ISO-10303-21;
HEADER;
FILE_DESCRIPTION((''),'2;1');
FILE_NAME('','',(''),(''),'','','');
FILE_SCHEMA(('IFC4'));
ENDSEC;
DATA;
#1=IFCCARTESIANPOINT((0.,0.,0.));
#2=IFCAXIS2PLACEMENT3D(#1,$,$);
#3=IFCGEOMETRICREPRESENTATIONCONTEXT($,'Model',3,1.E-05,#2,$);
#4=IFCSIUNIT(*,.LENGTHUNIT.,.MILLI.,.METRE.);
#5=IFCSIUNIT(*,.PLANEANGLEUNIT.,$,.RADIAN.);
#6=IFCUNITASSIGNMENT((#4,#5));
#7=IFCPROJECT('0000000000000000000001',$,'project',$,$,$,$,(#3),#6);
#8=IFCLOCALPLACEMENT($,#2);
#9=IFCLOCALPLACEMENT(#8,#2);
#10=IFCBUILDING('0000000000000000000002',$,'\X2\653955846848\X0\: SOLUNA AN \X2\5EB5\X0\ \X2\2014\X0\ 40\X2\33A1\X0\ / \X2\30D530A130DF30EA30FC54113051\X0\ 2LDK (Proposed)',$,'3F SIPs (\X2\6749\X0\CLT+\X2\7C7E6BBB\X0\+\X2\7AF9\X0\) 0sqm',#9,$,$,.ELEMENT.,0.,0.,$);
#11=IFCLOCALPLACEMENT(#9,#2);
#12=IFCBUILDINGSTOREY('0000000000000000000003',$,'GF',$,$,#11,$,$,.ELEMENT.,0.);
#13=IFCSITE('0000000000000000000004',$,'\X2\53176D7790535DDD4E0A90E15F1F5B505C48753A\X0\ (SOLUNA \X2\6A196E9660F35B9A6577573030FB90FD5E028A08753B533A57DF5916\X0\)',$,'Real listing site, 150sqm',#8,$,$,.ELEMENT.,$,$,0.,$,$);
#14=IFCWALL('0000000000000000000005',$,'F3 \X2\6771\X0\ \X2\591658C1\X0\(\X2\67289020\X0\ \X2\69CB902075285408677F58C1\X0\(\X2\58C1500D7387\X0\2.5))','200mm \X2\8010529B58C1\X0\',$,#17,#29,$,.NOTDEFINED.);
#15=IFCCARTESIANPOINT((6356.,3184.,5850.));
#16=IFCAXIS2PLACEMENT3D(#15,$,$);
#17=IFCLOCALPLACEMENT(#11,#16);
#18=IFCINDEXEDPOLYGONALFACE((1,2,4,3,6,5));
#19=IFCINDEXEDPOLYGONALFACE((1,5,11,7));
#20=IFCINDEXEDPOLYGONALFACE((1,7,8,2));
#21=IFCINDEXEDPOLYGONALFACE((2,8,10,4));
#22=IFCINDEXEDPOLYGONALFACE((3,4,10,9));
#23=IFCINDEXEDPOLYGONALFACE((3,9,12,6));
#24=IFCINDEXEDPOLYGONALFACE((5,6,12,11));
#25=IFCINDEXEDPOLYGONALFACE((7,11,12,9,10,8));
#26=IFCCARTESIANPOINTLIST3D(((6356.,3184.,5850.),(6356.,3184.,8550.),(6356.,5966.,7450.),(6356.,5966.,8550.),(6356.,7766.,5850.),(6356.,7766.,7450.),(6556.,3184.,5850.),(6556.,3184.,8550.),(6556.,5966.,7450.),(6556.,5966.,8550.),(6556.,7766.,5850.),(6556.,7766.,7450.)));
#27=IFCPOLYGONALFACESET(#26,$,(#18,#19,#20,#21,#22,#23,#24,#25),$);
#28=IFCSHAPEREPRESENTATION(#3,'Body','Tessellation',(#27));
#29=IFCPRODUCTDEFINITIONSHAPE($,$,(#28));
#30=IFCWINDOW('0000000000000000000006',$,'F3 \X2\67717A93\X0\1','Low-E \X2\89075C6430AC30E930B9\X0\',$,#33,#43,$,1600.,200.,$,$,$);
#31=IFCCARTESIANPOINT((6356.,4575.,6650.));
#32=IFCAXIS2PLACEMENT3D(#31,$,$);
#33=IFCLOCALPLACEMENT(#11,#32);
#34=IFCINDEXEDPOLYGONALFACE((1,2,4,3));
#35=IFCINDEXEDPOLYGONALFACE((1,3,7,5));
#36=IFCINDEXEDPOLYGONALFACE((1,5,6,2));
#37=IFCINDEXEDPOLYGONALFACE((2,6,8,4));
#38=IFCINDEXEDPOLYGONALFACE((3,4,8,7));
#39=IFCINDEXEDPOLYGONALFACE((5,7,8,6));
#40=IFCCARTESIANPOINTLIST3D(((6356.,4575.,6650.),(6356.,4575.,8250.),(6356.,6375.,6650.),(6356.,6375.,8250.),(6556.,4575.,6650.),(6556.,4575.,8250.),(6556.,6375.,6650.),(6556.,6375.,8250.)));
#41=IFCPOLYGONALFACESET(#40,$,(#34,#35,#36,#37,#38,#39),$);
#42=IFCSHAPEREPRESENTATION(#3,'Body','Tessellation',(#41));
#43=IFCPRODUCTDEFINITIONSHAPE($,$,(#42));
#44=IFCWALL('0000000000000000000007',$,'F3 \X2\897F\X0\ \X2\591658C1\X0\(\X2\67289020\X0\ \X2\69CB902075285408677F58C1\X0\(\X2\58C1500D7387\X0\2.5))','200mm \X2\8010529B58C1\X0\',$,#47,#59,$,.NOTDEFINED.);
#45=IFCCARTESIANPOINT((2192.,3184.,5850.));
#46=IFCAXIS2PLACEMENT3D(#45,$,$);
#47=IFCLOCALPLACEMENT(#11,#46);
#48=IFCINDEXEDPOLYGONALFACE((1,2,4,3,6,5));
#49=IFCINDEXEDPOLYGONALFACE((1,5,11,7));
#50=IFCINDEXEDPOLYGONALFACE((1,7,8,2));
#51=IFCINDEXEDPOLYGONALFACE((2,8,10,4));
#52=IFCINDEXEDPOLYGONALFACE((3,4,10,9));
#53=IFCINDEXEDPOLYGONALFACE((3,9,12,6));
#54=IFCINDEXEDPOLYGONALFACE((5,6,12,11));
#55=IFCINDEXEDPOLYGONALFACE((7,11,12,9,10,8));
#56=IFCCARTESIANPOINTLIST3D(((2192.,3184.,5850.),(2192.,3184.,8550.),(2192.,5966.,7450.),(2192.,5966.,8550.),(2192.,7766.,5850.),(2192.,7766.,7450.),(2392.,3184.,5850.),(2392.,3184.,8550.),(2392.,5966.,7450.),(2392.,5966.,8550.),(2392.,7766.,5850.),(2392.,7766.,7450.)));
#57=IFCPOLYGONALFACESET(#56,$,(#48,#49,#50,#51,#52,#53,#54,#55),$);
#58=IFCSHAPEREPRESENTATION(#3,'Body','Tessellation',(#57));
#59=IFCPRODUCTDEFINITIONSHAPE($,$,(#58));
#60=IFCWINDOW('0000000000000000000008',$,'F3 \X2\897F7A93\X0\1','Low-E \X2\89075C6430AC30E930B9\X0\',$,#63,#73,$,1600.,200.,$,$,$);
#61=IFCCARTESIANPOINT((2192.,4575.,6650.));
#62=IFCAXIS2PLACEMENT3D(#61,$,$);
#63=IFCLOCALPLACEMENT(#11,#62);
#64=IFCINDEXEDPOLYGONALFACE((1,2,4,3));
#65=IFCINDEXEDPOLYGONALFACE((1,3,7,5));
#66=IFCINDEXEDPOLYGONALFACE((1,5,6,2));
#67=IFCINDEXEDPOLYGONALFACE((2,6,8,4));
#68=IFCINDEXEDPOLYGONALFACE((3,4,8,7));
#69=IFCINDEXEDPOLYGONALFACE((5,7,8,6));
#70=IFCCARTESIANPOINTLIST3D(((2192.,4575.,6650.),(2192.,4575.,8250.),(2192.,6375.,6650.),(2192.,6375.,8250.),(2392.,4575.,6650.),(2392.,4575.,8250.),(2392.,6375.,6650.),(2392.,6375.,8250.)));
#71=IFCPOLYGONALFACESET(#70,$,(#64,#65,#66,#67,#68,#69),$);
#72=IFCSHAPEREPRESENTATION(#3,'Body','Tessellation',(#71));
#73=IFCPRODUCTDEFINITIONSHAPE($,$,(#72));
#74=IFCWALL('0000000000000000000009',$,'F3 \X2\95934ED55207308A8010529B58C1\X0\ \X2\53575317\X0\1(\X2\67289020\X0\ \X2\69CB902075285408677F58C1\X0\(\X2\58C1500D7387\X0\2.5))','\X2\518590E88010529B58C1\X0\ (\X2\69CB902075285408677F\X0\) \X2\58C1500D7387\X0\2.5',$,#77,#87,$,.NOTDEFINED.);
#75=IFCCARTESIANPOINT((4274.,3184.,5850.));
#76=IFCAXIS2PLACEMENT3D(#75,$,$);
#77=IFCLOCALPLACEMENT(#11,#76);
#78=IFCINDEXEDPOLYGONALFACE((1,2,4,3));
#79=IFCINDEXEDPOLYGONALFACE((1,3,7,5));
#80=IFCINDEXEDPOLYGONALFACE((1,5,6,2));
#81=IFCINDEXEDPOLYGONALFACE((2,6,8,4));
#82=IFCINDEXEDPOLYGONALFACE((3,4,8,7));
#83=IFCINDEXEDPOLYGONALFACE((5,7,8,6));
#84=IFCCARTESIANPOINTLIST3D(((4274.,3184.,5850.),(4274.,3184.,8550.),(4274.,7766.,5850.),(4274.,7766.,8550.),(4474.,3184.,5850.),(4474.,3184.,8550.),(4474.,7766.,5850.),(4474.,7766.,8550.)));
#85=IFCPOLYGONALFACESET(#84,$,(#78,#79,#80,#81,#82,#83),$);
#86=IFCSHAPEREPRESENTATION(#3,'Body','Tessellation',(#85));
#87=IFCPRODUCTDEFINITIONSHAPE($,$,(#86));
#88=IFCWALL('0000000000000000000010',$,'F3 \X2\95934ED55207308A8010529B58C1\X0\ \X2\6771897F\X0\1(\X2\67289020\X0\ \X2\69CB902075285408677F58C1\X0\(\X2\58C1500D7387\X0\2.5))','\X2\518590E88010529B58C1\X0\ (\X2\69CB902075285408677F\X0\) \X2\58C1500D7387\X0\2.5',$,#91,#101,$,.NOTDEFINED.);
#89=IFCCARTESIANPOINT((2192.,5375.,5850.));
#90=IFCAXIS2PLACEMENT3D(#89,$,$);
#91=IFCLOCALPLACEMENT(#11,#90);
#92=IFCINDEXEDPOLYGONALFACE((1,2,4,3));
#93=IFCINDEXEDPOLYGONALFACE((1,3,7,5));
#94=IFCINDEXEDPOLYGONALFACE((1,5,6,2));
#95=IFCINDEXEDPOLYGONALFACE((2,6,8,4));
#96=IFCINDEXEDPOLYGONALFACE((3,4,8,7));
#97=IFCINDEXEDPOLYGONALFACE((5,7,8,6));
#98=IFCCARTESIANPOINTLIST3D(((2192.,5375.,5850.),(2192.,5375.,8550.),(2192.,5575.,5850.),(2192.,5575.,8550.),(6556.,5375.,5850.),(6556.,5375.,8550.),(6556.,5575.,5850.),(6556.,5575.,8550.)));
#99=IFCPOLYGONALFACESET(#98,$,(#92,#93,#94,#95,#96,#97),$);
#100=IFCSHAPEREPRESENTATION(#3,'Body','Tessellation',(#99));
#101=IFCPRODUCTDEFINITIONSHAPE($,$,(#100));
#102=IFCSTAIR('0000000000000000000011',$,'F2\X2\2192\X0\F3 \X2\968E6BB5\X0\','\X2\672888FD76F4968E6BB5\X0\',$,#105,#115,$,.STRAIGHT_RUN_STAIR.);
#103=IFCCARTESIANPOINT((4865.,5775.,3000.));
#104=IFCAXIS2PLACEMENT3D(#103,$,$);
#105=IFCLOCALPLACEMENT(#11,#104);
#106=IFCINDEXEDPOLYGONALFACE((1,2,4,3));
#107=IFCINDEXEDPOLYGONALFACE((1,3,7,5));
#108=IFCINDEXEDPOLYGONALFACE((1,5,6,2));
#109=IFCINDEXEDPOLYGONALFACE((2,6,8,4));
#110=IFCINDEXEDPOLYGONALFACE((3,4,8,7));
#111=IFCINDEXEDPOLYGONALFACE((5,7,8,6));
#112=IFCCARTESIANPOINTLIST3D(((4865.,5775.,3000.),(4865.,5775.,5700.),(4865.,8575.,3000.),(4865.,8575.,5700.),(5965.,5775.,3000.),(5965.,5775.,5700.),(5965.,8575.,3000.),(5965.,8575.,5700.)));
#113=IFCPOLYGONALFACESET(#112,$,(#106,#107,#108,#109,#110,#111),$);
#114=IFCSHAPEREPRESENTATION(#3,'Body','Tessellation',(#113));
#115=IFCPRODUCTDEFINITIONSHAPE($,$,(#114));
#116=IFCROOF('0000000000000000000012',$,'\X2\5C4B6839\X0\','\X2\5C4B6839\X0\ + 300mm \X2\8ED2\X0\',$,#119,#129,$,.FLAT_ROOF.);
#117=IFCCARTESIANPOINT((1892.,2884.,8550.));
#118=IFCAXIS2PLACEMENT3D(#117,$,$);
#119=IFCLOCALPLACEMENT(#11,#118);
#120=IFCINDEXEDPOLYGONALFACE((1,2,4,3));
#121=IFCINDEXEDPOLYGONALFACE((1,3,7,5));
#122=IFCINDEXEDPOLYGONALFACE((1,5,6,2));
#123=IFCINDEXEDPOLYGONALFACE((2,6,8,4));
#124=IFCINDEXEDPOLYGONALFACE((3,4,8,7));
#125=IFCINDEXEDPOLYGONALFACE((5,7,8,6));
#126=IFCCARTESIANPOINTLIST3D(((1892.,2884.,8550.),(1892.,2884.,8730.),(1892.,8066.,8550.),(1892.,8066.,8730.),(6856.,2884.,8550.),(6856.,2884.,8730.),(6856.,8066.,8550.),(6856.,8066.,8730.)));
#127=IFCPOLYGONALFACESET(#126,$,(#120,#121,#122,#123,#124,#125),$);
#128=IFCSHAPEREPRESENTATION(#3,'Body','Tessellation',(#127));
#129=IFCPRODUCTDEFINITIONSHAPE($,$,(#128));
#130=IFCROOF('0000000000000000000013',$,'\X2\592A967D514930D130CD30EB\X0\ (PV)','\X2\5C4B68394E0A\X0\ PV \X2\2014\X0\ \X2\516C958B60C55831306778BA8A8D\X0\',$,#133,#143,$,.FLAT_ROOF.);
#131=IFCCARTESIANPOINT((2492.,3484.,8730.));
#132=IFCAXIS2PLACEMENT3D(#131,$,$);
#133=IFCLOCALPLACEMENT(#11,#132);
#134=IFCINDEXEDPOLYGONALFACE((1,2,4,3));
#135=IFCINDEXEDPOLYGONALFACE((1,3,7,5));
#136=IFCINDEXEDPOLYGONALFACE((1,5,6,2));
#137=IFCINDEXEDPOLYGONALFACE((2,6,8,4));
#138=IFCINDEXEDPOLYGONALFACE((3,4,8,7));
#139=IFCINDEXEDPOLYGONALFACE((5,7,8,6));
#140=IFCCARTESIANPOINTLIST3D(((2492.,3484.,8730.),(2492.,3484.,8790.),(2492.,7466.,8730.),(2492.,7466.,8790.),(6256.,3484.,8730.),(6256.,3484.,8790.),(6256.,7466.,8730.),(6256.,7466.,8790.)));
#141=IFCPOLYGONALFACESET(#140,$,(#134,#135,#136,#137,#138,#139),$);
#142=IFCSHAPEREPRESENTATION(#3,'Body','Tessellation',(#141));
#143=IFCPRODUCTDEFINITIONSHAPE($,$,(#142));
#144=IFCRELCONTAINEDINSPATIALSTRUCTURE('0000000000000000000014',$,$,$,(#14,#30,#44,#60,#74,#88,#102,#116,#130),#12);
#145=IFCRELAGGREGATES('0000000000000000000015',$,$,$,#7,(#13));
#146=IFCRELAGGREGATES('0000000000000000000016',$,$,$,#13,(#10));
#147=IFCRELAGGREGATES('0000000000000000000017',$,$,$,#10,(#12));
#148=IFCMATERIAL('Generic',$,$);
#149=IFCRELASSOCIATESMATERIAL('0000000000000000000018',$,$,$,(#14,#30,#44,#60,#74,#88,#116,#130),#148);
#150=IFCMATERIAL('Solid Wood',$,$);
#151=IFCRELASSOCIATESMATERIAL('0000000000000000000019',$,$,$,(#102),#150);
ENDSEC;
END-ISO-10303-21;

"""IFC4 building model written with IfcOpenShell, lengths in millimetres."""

from ifc_helpers import new_model, si_unit, frame, frame_2d, origin, place, context, project, spatial, rectangle, extrude, material, element, fill, save


model = new_model("IFC4")

# Units and contexts
model_context = context("Model", 3, precision=1e-05, world=origin())
ifc_project = project(units=[si_unit("LENGTHUNIT", "METRE", prefix="MILLI"), si_unit("PLANEANGLEUNIT", "RADIAN")], contexts=[model_context])

# Site, building, storey
site_placement = place(None, origin())
site = spatial("IfcSite", under=ifc_project, at=site_placement, Name="北海道川上郡弟子屈町 (SOLUNA 標準想定敷地・都市計画区域外)", ObjectType="Real listing site, 150sqm", CompositionType="ELEMENT", RefElevation=0.0)
building_placement = place(site_placement, origin())
building = spatial("IfcBuilding", under=site, at=building_placement, Name="改善案: SOLUNA AN 庵 — 40㎡ / ファミリー向け 2LDK (Proposed)", ObjectType="3F SIPs (杉CLT+籾殻+竹) 0sqm", CompositionType="ELEMENT", ElevationOfRefHeight=0.0, ElevationOfTerrain=0.0)
storey_placement = place(building_placement, origin())
storey = spatial("IfcBuildingStorey", under=building, at=storey_placement, Name="GF", CompositionType="ELEMENT", Elevation=0.0)

# Shared definitions
ifc_material_1 = material(Name="Generic")

# Walls, openings, windows
wall_1_placement = place(storey_placement, frame((6356.0, 3184.0, 5850.0)))
wall_1 = element("IfcWall", 1, at=wall_1_placement, inside=storey, material=ifc_material_1, Name="F3 東 外壁(木造 構造用合板壁(壁倍率2.5))", Description="200mm 耐力壁", PredefinedType="NOTDEFINED", context=model_context, shape_type="SweptSolid", body=[
    extrude(rectangle(XDim=200.0, YDim=4582.0, at=frame_2d((100.0, 2291.0))), frame((6356.0, 3184.0, 5850.0)), (0.0, 0.0, 1.0), 2700.0),
])
opening_1_placement = place(storey_placement, frame((6356.0, 4575.0, 6650.0)))
opening_1 = element("IfcOpeningElement", 2, at=opening_1_placement, cuts=wall_1, PredefinedType="NOTDEFINED", context=model_context, shape_type="SweptSolid", body=[
    extrude(rectangle(XDim=200.0, YDim=1800.0, at=frame_2d((100.0, 900.0))), frame((6356.0, 4575.0, 6650.0)), (0.0, 0.0, 1.0), 1600.0),
])
window_1_placement = place(storey_placement, frame((6356.0, 4575.0, 6650.0)))
window_1 = element("IfcWindow", 3, at=window_1_placement, inside=storey, material=ifc_material_1, Name="F3 東窓1", Description="Low-E 複層ガラス", OverallHeight=1600.0, OverallWidth=200.0, context=model_context, shape_type="SweptSolid", body=[
    extrude(rectangle(XDim=200.0, YDim=1800.0, at=frame_2d((100.0, 900.0))), frame((6356.0, 4575.0, 6650.0)), (0.0, 0.0, 1.0), 1600.0),
])
fill(opening_1, window_1)
wall_2_placement = place(storey_placement, frame((2192.0, 3184.0, 5850.0)))
wall_2 = element("IfcWall", 4, at=wall_2_placement, inside=storey, material=ifc_material_1, Name="F3 西 外壁(木造 構造用合板壁(壁倍率2.5))", Description="200mm 耐力壁", PredefinedType="NOTDEFINED", context=model_context, shape_type="SweptSolid", body=[
    extrude(rectangle(XDim=200.0, YDim=4582.0, at=frame_2d((100.0, 2291.0))), frame((2192.0, 3184.0, 5850.0)), (0.0, 0.0, 1.0), 2700.0),
])
opening_2_placement = place(storey_placement, frame((2192.0, 4575.0, 6650.0)))
opening_2 = element("IfcOpeningElement", 5, at=opening_2_placement, cuts=wall_2, PredefinedType="NOTDEFINED", context=model_context, shape_type="SweptSolid", body=[
    extrude(rectangle(XDim=200.0, YDim=1800.0, at=frame_2d((100.0, 900.0))), frame((2192.0, 4575.0, 6650.0)), (0.0, 0.0, 1.0), 1600.0),
])
window_2_placement = place(storey_placement, frame((2192.0, 4575.0, 6650.0)))
window_2 = element("IfcWindow", 6, at=window_2_placement, inside=storey, material=ifc_material_1, Name="F3 西窓1", Description="Low-E 複層ガラス", OverallHeight=1600.0, OverallWidth=200.0, context=model_context, shape_type="SweptSolid", body=[
    extrude(rectangle(XDim=200.0, YDim=1800.0, at=frame_2d((100.0, 900.0))), frame((2192.0, 4575.0, 6650.0)), (0.0, 0.0, 1.0), 1600.0),
])
fill(opening_2, window_2)

# Walls
wall_3_placement = place(storey_placement, frame((4274.0, 3184.0, 5850.0)))
element("IfcWall", 7, at=wall_3_placement, inside=storey, material=ifc_material_1, Name="F3 間仕切り耐力壁 南北1(木造 構造用合板壁(壁倍率2.5))", Description="内部耐力壁 (構造用合板) 壁倍率2.5", PredefinedType="NOTDEFINED", context=model_context, shape_type="SweptSolid", body=[
    extrude(rectangle(XDim=200.0, YDim=4582.0, at=frame_2d((100.0, 2291.0))), frame((4274.0, 3184.0, 5850.0)), (0.0, 0.0, 1.0), 2700.0),
])
wall_4_placement = place(storey_placement, frame((2192.0, 5375.0, 5850.0)))
element("IfcWall", 8, at=wall_4_placement, inside=storey, material=ifc_material_1, Name="F3 間仕切り耐力壁 東西1(木造 構造用合板壁(壁倍率2.5))", Description="内部耐力壁 (構造用合板) 壁倍率2.5", PredefinedType="NOTDEFINED", context=model_context, shape_type="SweptSolid", body=[
    extrude(rectangle(XDim=4364.0, YDim=200.0, at=frame_2d((2182.0, 100.0))), frame((2192.0, 5375.0, 5850.0)), (0.0, 0.0, 1.0), 2700.0),
])

# Stair
ifc_material_2 = material(Name="Solid Wood")
stair_placement = place(storey_placement, frame((4865.0, 5775.0, 3000.0)))
element("IfcStair", 9, at=stair_placement, inside=storey, material=ifc_material_2, Name="F2→F3 階段", Description="木製直階段", PredefinedType="STRAIGHT_RUN_STAIR", context=model_context, shape_type="SweptSolid", body=[
    extrude(rectangle(XDim=1100.0, YDim=2800.0, at=frame_2d((550.0, 1400.0))), frame((4865.0, 5775.0, 3000.0)), (0.0, 0.0, 1.0), 2700.0),
])

# Roofs
roof_1_placement = place(storey_placement, frame((1892.0, 2884.0, 8550.0)))
element("IfcRoof", 10, at=roof_1_placement, inside=storey, material=ifc_material_1, Name="屋根", Description="屋根 + 300mm 軒", PredefinedType="FLAT_ROOF", context=model_context, shape_type="SweptSolid", body=[
    extrude(rectangle(XDim=4964.0, YDim=5182.0, at=frame_2d((2482.0, 2591.0))), frame((1892.0, 2884.0, 8550.0)), (0.0, 0.0, 1.0), 180.0),
])
roof_2_placement = place(storey_placement, frame((2492.0, 3484.0, 8730.0)))
element("IfcRoof", 11, at=roof_2_placement, inside=storey, material=ifc_material_1, Name="太陽光パネル (PV)", Description="屋根上 PV — 公開情報で確認", PredefinedType="FLAT_ROOF", context=model_context, shape_type="SweptSolid", body=[
    extrude(rectangle(XDim=3764.0, YDim=3982.0, at=frame_2d((1882.0, 1991.0))), frame((2492.0, 3484.0, 8730.0)), (0.0, 0.0, 1.0), 60.0),
])

save(model, "model.ifc")
